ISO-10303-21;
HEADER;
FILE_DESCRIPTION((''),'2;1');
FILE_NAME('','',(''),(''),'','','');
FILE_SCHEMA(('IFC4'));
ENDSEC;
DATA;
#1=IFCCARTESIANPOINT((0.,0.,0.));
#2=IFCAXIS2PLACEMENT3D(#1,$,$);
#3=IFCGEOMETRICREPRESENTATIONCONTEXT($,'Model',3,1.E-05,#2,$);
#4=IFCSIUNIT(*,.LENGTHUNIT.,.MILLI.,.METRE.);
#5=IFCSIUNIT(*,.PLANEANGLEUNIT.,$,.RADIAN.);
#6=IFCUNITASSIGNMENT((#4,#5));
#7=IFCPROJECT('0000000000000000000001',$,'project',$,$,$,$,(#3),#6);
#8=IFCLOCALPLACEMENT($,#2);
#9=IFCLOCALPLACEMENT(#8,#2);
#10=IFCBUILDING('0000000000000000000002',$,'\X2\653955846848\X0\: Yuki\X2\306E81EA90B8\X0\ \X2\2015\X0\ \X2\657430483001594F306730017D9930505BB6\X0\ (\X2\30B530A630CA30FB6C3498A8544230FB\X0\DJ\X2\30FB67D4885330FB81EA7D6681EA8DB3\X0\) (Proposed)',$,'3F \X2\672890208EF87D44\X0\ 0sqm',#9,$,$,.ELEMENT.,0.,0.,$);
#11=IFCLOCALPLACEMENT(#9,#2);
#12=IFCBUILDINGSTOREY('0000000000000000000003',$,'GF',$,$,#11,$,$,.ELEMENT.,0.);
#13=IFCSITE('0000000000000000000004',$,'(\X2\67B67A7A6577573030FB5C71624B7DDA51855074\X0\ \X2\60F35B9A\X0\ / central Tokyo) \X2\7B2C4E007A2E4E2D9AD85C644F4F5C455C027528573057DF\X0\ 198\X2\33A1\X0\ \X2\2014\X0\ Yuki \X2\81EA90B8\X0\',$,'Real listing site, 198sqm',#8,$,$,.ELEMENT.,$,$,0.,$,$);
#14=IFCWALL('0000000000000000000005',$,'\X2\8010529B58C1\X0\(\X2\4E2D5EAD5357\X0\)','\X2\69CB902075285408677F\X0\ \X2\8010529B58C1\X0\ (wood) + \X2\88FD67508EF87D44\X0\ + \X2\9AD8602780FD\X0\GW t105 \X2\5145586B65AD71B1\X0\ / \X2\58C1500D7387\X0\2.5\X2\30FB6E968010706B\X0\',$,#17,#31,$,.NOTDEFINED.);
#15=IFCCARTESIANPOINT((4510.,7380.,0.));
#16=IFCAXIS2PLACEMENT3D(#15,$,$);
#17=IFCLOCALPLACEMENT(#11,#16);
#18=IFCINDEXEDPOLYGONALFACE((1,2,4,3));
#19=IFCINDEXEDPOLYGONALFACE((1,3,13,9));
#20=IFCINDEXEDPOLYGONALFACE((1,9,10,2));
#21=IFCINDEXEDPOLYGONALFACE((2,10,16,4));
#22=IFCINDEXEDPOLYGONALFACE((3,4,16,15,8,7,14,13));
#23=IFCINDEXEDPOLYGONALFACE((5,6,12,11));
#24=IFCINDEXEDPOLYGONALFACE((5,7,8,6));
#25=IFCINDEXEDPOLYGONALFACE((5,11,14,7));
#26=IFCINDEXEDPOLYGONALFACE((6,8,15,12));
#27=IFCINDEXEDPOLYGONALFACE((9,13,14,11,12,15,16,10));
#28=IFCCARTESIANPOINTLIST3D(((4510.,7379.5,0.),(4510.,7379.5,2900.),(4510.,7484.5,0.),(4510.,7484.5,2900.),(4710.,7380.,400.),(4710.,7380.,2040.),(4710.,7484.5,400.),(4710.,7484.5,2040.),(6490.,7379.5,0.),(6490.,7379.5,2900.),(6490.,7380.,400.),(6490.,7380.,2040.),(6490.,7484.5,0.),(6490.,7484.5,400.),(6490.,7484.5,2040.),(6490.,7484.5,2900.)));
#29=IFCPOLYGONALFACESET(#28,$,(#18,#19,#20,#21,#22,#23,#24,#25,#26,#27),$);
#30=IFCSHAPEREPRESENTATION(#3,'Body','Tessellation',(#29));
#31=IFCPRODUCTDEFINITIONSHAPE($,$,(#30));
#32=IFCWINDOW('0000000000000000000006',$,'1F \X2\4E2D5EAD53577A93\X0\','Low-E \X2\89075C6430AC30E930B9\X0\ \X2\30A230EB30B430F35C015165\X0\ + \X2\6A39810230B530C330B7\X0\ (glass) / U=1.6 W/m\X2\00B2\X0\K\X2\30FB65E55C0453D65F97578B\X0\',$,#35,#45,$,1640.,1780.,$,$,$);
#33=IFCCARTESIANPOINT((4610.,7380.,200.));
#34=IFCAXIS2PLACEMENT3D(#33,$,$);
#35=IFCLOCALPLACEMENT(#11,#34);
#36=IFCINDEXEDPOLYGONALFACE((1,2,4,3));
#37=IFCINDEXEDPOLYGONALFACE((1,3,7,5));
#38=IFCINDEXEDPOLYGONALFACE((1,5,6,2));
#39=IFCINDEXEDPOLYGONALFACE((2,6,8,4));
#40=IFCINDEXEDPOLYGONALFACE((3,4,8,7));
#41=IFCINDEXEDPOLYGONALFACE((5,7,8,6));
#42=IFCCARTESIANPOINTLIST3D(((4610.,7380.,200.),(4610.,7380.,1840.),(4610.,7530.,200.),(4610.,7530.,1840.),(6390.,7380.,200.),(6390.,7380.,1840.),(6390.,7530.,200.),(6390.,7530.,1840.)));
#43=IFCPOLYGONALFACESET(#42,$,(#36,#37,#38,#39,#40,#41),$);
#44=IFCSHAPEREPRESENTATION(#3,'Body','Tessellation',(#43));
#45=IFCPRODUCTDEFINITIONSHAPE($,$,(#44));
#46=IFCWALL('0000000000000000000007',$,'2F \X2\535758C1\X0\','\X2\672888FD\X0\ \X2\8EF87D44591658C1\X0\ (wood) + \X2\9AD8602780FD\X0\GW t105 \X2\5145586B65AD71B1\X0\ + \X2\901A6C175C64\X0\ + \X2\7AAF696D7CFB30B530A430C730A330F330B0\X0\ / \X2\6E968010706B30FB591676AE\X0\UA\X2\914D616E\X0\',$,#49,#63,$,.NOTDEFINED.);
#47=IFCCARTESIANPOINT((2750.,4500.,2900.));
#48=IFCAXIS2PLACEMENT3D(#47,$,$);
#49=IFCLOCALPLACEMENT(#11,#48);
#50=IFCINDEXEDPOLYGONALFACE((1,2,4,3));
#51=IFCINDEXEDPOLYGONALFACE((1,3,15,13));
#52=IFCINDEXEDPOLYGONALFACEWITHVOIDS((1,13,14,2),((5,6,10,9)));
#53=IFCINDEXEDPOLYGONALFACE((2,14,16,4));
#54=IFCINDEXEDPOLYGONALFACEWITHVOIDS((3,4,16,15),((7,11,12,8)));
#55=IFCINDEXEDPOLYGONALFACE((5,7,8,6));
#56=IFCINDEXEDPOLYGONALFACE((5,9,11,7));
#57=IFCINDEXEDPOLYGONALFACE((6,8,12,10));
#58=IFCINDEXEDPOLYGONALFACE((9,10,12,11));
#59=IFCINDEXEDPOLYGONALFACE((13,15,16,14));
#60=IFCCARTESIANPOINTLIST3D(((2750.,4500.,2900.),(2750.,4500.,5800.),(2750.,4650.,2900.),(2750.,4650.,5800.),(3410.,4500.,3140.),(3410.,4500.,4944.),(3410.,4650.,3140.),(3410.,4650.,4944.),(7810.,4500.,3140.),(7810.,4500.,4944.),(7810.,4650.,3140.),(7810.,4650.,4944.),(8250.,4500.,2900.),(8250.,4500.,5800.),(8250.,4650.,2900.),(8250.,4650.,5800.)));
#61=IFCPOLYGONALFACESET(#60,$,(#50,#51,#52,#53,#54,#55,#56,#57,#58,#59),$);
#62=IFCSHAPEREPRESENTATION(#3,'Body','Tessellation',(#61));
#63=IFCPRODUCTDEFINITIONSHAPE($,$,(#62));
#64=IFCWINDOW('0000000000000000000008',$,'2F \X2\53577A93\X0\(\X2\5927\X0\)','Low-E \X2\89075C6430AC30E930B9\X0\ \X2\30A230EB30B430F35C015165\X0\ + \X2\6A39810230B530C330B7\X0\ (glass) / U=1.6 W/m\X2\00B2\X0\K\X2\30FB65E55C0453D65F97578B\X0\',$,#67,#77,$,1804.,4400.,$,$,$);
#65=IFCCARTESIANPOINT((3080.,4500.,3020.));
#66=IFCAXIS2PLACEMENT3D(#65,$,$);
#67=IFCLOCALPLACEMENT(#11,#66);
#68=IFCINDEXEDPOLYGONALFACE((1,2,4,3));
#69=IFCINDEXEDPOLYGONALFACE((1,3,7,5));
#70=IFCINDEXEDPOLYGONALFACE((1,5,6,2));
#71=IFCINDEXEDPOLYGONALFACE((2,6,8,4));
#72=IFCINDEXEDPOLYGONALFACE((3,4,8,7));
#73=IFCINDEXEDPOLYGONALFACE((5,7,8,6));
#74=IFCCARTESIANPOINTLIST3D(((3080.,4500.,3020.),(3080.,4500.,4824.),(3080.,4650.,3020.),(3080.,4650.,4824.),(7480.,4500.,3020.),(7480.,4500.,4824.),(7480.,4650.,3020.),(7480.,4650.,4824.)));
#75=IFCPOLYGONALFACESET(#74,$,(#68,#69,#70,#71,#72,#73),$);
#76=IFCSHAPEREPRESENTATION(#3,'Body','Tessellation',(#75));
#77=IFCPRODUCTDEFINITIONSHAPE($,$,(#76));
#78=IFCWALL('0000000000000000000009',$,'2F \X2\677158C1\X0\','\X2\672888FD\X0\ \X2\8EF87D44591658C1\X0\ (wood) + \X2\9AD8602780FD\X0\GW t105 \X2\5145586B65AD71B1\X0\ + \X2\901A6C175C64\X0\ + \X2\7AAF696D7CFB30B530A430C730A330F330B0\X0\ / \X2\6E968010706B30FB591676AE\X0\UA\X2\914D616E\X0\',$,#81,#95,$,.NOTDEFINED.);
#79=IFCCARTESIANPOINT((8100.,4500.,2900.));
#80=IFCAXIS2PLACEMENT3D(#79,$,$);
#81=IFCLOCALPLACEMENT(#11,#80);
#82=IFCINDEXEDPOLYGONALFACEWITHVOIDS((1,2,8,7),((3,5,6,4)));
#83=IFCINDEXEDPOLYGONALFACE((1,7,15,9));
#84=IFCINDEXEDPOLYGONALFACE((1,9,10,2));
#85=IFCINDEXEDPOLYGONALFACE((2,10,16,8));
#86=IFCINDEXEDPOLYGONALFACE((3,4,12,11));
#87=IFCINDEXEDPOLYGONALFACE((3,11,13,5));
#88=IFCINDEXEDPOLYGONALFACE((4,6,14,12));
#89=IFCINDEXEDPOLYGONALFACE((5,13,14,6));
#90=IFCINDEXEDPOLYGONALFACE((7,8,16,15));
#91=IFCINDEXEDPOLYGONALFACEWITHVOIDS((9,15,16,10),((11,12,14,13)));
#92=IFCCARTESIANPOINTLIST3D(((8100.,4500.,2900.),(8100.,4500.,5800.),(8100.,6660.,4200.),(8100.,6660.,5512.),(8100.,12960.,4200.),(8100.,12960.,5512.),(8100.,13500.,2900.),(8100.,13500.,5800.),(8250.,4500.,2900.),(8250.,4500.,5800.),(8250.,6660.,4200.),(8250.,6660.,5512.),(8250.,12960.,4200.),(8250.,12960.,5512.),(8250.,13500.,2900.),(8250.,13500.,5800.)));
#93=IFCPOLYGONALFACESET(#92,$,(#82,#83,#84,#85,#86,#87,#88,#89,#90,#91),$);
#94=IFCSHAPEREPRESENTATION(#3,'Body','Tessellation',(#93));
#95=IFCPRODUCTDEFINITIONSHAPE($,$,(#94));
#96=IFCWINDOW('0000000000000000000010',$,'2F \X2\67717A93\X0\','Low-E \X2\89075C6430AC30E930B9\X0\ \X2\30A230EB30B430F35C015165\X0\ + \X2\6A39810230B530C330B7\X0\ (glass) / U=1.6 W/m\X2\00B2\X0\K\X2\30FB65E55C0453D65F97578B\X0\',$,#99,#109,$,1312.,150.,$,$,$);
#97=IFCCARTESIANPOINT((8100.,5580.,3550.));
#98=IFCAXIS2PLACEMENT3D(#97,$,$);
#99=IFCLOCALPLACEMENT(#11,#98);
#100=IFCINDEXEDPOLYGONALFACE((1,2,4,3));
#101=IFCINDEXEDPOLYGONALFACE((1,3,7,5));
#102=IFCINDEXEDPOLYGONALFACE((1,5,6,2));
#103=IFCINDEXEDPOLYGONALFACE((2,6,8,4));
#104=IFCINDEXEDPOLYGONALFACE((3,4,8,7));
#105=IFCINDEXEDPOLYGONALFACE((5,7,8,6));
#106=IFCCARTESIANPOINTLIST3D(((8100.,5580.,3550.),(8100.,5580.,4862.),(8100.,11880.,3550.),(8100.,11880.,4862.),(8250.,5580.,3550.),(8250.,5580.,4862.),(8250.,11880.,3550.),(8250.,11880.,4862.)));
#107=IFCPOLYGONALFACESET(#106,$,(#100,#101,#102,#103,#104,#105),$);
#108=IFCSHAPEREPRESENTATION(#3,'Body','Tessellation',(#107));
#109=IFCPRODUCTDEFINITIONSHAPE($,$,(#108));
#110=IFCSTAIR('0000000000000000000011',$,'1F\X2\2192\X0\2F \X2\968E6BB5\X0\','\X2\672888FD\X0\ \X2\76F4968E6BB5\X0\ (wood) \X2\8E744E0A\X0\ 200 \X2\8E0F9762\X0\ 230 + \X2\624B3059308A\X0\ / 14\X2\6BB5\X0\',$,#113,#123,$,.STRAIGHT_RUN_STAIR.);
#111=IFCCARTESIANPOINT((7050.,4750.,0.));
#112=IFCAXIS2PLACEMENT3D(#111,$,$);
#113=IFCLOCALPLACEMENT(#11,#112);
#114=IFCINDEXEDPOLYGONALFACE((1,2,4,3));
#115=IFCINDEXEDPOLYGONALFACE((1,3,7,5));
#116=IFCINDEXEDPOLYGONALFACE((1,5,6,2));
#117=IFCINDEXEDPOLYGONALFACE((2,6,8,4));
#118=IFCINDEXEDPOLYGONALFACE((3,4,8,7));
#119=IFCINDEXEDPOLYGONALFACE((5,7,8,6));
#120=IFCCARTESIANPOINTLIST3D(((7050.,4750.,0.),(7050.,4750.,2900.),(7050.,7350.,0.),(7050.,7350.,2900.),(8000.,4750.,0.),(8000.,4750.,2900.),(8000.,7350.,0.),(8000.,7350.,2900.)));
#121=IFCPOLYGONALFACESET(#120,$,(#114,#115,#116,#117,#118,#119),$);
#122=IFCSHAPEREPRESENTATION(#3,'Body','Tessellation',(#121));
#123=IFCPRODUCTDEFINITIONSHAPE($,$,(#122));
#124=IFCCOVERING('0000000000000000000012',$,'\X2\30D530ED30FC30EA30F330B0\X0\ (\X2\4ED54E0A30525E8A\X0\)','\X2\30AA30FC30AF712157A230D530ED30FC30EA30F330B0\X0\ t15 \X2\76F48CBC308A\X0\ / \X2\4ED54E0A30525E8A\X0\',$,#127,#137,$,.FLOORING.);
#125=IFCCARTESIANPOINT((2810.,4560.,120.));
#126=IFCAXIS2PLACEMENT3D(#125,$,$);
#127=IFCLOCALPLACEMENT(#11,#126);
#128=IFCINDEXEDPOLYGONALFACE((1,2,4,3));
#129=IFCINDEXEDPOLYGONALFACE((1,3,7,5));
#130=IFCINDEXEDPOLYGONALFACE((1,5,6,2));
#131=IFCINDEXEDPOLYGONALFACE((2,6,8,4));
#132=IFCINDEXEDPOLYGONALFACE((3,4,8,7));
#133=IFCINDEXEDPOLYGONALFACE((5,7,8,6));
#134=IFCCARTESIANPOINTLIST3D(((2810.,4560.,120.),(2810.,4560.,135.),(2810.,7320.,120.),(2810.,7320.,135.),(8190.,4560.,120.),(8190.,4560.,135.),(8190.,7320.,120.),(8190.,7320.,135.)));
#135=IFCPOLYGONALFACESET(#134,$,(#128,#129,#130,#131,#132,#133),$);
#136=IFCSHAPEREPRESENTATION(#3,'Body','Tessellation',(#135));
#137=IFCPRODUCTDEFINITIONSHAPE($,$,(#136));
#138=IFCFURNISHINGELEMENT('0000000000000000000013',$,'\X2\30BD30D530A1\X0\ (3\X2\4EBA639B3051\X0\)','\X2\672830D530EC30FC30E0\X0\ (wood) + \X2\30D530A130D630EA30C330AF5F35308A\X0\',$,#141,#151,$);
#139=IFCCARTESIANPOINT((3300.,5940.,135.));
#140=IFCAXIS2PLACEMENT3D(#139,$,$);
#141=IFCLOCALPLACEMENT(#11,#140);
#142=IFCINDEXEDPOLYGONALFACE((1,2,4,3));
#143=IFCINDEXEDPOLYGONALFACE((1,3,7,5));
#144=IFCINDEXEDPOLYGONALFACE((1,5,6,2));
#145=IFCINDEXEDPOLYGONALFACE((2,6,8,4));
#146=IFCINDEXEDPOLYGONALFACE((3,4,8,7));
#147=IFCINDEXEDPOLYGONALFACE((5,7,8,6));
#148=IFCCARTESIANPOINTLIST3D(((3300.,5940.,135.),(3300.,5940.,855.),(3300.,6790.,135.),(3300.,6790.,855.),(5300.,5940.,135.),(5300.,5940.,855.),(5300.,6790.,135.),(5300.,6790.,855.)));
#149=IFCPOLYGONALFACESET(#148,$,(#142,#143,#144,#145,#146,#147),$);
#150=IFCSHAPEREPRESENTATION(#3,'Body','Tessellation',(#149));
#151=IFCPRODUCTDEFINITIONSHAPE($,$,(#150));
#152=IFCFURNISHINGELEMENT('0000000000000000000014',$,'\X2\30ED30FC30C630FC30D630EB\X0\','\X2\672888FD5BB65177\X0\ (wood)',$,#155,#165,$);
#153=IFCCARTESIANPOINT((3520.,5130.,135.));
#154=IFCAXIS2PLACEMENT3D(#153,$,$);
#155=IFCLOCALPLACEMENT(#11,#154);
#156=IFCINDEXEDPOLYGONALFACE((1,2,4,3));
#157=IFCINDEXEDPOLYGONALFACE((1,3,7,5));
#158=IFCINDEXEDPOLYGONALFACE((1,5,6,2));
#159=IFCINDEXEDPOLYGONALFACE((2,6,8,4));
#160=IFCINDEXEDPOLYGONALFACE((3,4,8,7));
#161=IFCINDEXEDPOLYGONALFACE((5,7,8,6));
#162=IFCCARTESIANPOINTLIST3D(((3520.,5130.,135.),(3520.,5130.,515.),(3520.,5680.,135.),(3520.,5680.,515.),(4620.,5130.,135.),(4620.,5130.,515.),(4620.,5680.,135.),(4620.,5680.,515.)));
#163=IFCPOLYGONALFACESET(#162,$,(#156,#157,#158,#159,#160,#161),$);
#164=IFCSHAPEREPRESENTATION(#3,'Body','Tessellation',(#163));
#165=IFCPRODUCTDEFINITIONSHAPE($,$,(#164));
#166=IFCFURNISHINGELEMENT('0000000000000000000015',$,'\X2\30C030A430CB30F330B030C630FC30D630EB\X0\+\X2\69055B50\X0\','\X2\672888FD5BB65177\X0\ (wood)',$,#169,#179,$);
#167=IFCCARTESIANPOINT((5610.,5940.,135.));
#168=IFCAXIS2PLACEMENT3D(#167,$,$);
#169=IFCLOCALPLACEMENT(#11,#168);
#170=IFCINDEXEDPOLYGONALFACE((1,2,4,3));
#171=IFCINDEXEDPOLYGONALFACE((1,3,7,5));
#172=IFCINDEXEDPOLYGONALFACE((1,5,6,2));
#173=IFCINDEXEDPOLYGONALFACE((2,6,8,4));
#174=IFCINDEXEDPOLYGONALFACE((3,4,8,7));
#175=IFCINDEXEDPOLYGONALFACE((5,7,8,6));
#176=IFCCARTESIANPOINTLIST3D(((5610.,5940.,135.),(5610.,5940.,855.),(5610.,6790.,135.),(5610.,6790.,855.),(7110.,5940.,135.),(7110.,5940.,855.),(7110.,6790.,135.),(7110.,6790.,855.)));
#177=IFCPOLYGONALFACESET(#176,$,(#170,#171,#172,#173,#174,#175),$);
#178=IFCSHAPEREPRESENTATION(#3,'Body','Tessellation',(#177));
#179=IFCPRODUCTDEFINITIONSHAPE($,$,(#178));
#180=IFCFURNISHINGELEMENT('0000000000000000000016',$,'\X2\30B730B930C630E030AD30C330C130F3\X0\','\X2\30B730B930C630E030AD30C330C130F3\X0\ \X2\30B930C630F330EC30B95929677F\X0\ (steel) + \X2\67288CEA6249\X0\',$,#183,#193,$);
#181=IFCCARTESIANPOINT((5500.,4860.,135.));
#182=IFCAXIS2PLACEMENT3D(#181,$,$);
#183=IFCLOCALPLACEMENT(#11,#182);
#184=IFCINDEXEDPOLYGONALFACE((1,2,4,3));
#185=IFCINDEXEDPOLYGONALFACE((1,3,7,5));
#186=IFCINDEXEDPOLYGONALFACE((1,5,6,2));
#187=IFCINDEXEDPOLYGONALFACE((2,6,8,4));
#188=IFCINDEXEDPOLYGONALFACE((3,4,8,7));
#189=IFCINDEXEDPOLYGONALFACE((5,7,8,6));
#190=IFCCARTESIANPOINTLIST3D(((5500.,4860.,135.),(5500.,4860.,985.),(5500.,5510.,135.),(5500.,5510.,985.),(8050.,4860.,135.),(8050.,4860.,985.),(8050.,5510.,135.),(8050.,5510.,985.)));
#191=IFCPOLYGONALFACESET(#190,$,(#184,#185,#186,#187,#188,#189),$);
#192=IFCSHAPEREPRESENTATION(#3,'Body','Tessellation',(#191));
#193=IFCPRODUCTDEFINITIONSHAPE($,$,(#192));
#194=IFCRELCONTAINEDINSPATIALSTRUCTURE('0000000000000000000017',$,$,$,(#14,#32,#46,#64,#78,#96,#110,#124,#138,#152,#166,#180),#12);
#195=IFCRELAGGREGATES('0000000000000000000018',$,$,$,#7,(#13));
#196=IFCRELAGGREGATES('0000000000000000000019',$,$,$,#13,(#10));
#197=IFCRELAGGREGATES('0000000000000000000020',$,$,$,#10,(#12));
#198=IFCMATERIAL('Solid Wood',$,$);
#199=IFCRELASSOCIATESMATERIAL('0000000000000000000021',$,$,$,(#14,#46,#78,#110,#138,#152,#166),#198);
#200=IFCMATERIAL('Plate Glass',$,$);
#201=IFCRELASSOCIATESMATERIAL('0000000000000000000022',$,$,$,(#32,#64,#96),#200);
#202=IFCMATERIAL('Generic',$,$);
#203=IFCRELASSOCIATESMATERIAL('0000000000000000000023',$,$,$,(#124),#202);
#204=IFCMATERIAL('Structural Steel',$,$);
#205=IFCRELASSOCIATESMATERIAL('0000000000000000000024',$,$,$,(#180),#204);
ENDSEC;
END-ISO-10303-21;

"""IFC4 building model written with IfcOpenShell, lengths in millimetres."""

from ifc_helpers import new_model, si_unit, frame, frame_2d, origin, place, context, project, spatial, rectangle, extrude, material, element, fill, save


model = new_model("IFC4")

# Units and contexts
model_context = context("Model", 3, precision=1e-05, world=origin())
ifc_project = project(units=[si_unit("LENGTHUNIT", "METRE", prefix="MILLI"), si_unit("PLANEANGLEUNIT", "RADIAN")], contexts=[model_context])

# Site, building, storey
site_placement = place(None, origin())
site = spatial("IfcSite", under=ifc_project, at=site_placement, Name="(架空敷地・山手線内側 想定 / central Tokyo) 第一種中高層住居専用地域 198㎡ — Yuki 自邸", ObjectType="Real listing site, 198sqm", CompositionType="ELEMENT", RefElevation=0.0)
building_placement = place(site_placement, origin())
building = spatial("IfcBuilding", under=site, at=building_placement, Name="改善案: Yukiの自邸 ― 整え、奏で、継ぐ家 (サウナ・水風呂・DJ・柔術・自給自足) (Proposed)", ObjectType="3F 木造軸組 0sqm", CompositionType="ELEMENT", ElevationOfRefHeight=0.0, ElevationOfTerrain=0.0)
storey_placement = place(building_placement, origin())
storey = spatial("IfcBuildingStorey", under=building, at=storey_placement, Name="GF", CompositionType="ELEMENT", Elevation=0.0)

# Shared definitions
ifc_material_1 = material(Name="Solid Wood")
ifc_material_2 = material(Name="Generic")

# Shared definitions
ifc_material_3 = material(Name="Plate Glass")

# Wall, opening, window
wall_1_placement = place(storey_placement, frame((4510.0, 7380.0, 0.0)))
wall_1 = element("IfcWall", 1, at=wall_1_placement, inside=storey, material=ifc_material_1, Name="耐力壁(中庭南)", Description="構造用合板 耐力壁 (wood) + 製材軸組 + 高性能GW t105 充填断熱 / 壁倍率2.5・準耐火", PredefinedType="NOTDEFINED", context=model_context, shape_type="SweptSolid", body=[
    extrude(rectangle(XDim=1980.0, YDim=105.0, at=frame_2d((990.0, 52.0))), frame((4510.0, 7380.0, 0.0)), (0.0, 0.0, 1.0), 2900.0),
])
opening_1_placement = place(storey_placement, frame((4610.0, 7380.0, 200.0)))
opening_1 = element("IfcOpeningElement", 2, at=opening_1_placement, cuts=wall_1, PredefinedType="NOTDEFINED", context=model_context, shape_type="SweptSolid", body=[
    extrude(rectangle(XDim=1780.0, YDim=150.0, at=frame_2d((890.0, 75.0))), frame((4610.0, 7380.0, 200.0)), (0.0, 0.0, 1.0), 1640.0),
])
window_1_placement = place(storey_placement, frame((4610.0, 7380.0, 200.0)))
window_1 = element("IfcWindow", 3, at=window_1_placement, inside=storey, material=ifc_material_3, Name="1F 中庭南窓", Description="Low-E 複層ガラス アルゴン封入 + 樹脂サッシ (glass) / U=1.6 W/m²K・日射取得型", OverallHeight=1640.0, OverallWidth=1780.0, context=model_context, shape_type="SweptSolid", body=[
    extrude(rectangle(XDim=1780.0, YDim=150.0, at=frame_2d((890.0, 75.0))), frame((4610.0, 7380.0, 200.0)), (0.0, 0.0, 1.0), 1640.0),
])
fill(opening_1, window_1)

# Walls, openings, windows
wall_2_placement = place(storey_placement, frame((2750.0, 4500.0, 2900.0)))
wall_2 = element("IfcWall", 4, at=wall_2_placement, inside=storey, material=ifc_material_1, Name="2F 南壁", Description="木製 軸組外壁 (wood) + 高性能GW t105 充填断熱 + 通気層 + 窯業系サイディング / 準耐火・外皮UA配慮", PredefinedType="NOTDEFINED", context=model_context, shape_type="SweptSolid", body=[
    extrude(rectangle(XDim=5500.0, YDim=150.0, at=frame_2d((2750.0, 75.0))), frame((2750.0, 4500.0, 2900.0)), (0.0, 0.0, 1.0), 2900.0),
])
opening_2_placement = place(storey_placement, frame((3080.0, 4500.0, 3020.0)))
opening_2 = element("IfcOpeningElement", 5, at=opening_2_placement, cuts=wall_2, PredefinedType="NOTDEFINED", context=model_context, shape_type="SweptSolid", body=[
    extrude(rectangle(XDim=4400.0, YDim=150.0, at=frame_2d((2200.0, 75.0))), frame((3080.0, 4500.0, 3020.0)), (0.0, 0.0, 1.0), 1804.0),
])
window_2_placement = place(storey_placement, frame((3080.0, 4500.0, 3020.0)))
window_2 = element("IfcWindow", 6, at=window_2_placement, inside=storey, material=ifc_material_3, Name="2F 南窓(大)", Description="Low-E 複層ガラス アルゴン封入 + 樹脂サッシ (glass) / U=1.6 W/m²K・日射取得型", OverallHeight=1804.0, OverallWidth=4400.0, context=model_context, shape_type="SweptSolid", body=[
    extrude(rectangle(XDim=4400.0, YDim=150.0, at=frame_2d((2200.0, 75.0))), frame((3080.0, 4500.0, 3020.0)), (0.0, 0.0, 1.0), 1804.0),
])
fill(opening_2, window_2)
wall_3_placement = place(storey_placement, frame((8100.0, 4500.0, 2900.0)))
wall_3 = element("IfcWall", 7, at=wall_3_placement, inside=storey, material=ifc_material_1, Name="2F 東壁", Description="木製 軸組外壁 (wood) + 高性能GW t105 充填断熱 + 通気層 + 窯業系サイディング / 準耐火・外皮UA配慮", PredefinedType="NOTDEFINED", context=model_context, shape_type="SweptSolid", body=[
    extrude(rectangle(XDim=150.0, YDim=9000.0, at=frame_2d((75.0, 4500.0))), frame((8100.0, 4500.0, 2900.0)), (0.0, 0.0, 1.0), 2900.0),
])
opening_3_placement = place(storey_placement, frame((8100.0, 5580.0, 3550.0)))
opening_3 = element("IfcOpeningElement", 8, at=opening_3_placement, cuts=wall_3, PredefinedType="NOTDEFINED", context=model_context, shape_type="SweptSolid", body=[
    extrude(rectangle(XDim=150.0, YDim=6300.0, at=frame_2d((75.0, 3150.0))), frame((8100.0, 5580.0, 3550.0)), (0.0, 0.0, 1.0), 1312.0),
])
window_3_placement = place(storey_placement, frame((8100.0, 5580.0, 3550.0)))
window_3 = element("IfcWindow", 9, at=window_3_placement, inside=storey, material=ifc_material_3, Name="2F 東窓", Description="Low-E 複層ガラス アルゴン封入 + 樹脂サッシ (glass) / U=1.6 W/m²K・日射取得型", OverallHeight=1312.0, OverallWidth=150.0, context=model_context, shape_type="SweptSolid", body=[
    extrude(rectangle(XDim=150.0, YDim=6300.0, at=frame_2d((75.0, 3150.0))), frame((8100.0, 5580.0, 3550.0)), (0.0, 0.0, 1.0), 1312.0),
])
fill(opening_3, window_3)

# Stair
stair_placement = place(storey_placement, frame((7050.0, 4750.0, 0.0)))
element("IfcStair", 10, at=stair_placement, inside=storey, material=ifc_material_1, Name="1F→2F 階段", Description="木製 直階段 (wood) 蹴上 200 踏面 230 + 手すり / 14段", PredefinedType="STRAIGHT_RUN_STAIR", context=model_context, shape_type="SweptSolid", body=[
    extrude(rectangle(XDim=950.0, YDim=2600.0, at=frame_2d((475.0, 1300.0))), frame((7050.0, 4750.0, 0.0)), (0.0, 0.0, 1.0), 2900.0),
])

# Covering
covering_placement = place(storey_placement, frame((2810.0, 4560.0, 120.0)))
element("IfcCovering", 11, at=covering_placement, inside=storey, material=ifc_material_2, Name="フローリング (仕上げ床)", Description="オーク無垢フローリング t15 直貼り / 仕上げ床", PredefinedType="FLOORING", context=model_context, shape_type="SweptSolid", body=[
    extrude(rectangle(XDim=5380.0, YDim=2760.0, at=frame_2d((2690.0, 1380.0))), frame((2810.0, 4560.0, 120.0)), (0.0, 0.0, 1.0), 15.0),
])

# Furnishing elements
furnishing_1_placement = place(storey_placement, frame((3300.0, 5940.0, 135.0)))
element("IfcFurnishingElement", 12, at=furnishing_1_placement, inside=storey, material=ifc_material_1, Name="ソファ (3人掛け)", Description="木フレーム (wood) + ファブリック張り", context=model_context, shape_type="SweptSolid", body=[
    extrude(rectangle(XDim=2000.0, YDim=850.0, at=frame_2d((1000.0, 425.0))), frame((3300.0, 5940.0, 135.0)), (0.0, 0.0, 1.0), 720.0),
])
furnishing_2_placement = place(storey_placement, frame((3520.0, 5130.0, 135.0)))
element("IfcFurnishingElement", 13, at=furnishing_2_placement, inside=storey, material=ifc_material_1, Name="ローテーブル", Description="木製家具 (wood)", context=model_context, shape_type="SweptSolid", body=[
    extrude(rectangle(XDim=1100.0, YDim=550.0, at=frame_2d((550.0, 275.0))), frame((3520.0, 5130.0, 135.0)), (0.0, 0.0, 1.0), 380.0),
])
furnishing_3_placement = place(storey_placement, frame((5610.0, 5940.0, 135.0)))
element("IfcFurnishingElement", 14, at=furnishing_3_placement, inside=storey, material=ifc_material_1, Name="ダイニングテーブル+椅子", Description="木製家具 (wood)", context=model_context, shape_type="SweptSolid", body=[
    extrude(rectangle(XDim=1500.0, YDim=850.0, at=frame_2d((750.0, 425.0))), frame((5610.0, 5940.0, 135.0)), (0.0, 0.0, 1.0), 720.0),
])
ifc_material_4 = material(Name="Structural Steel")
furnishing_4_placement = place(storey_placement, frame((5500.0, 4860.0, 135.0)))
element("IfcFurnishingElement", 15, at=furnishing_4_placement, inside=storey, material=ifc_material_4, Name="システムキッチン", Description="システムキッチン ステンレス天板 (steel) + 木質扉", context=model_context, shape_type="SweptSolid", body=[
    extrude(rectangle(XDim=2550.0, YDim=650.0, at=frame_2d((1275.0, 325.0))), frame((5500.0, 4860.0, 135.0)), (0.0, 0.0, 1.0), 850.0),
])

save(model, "model.ifc")
